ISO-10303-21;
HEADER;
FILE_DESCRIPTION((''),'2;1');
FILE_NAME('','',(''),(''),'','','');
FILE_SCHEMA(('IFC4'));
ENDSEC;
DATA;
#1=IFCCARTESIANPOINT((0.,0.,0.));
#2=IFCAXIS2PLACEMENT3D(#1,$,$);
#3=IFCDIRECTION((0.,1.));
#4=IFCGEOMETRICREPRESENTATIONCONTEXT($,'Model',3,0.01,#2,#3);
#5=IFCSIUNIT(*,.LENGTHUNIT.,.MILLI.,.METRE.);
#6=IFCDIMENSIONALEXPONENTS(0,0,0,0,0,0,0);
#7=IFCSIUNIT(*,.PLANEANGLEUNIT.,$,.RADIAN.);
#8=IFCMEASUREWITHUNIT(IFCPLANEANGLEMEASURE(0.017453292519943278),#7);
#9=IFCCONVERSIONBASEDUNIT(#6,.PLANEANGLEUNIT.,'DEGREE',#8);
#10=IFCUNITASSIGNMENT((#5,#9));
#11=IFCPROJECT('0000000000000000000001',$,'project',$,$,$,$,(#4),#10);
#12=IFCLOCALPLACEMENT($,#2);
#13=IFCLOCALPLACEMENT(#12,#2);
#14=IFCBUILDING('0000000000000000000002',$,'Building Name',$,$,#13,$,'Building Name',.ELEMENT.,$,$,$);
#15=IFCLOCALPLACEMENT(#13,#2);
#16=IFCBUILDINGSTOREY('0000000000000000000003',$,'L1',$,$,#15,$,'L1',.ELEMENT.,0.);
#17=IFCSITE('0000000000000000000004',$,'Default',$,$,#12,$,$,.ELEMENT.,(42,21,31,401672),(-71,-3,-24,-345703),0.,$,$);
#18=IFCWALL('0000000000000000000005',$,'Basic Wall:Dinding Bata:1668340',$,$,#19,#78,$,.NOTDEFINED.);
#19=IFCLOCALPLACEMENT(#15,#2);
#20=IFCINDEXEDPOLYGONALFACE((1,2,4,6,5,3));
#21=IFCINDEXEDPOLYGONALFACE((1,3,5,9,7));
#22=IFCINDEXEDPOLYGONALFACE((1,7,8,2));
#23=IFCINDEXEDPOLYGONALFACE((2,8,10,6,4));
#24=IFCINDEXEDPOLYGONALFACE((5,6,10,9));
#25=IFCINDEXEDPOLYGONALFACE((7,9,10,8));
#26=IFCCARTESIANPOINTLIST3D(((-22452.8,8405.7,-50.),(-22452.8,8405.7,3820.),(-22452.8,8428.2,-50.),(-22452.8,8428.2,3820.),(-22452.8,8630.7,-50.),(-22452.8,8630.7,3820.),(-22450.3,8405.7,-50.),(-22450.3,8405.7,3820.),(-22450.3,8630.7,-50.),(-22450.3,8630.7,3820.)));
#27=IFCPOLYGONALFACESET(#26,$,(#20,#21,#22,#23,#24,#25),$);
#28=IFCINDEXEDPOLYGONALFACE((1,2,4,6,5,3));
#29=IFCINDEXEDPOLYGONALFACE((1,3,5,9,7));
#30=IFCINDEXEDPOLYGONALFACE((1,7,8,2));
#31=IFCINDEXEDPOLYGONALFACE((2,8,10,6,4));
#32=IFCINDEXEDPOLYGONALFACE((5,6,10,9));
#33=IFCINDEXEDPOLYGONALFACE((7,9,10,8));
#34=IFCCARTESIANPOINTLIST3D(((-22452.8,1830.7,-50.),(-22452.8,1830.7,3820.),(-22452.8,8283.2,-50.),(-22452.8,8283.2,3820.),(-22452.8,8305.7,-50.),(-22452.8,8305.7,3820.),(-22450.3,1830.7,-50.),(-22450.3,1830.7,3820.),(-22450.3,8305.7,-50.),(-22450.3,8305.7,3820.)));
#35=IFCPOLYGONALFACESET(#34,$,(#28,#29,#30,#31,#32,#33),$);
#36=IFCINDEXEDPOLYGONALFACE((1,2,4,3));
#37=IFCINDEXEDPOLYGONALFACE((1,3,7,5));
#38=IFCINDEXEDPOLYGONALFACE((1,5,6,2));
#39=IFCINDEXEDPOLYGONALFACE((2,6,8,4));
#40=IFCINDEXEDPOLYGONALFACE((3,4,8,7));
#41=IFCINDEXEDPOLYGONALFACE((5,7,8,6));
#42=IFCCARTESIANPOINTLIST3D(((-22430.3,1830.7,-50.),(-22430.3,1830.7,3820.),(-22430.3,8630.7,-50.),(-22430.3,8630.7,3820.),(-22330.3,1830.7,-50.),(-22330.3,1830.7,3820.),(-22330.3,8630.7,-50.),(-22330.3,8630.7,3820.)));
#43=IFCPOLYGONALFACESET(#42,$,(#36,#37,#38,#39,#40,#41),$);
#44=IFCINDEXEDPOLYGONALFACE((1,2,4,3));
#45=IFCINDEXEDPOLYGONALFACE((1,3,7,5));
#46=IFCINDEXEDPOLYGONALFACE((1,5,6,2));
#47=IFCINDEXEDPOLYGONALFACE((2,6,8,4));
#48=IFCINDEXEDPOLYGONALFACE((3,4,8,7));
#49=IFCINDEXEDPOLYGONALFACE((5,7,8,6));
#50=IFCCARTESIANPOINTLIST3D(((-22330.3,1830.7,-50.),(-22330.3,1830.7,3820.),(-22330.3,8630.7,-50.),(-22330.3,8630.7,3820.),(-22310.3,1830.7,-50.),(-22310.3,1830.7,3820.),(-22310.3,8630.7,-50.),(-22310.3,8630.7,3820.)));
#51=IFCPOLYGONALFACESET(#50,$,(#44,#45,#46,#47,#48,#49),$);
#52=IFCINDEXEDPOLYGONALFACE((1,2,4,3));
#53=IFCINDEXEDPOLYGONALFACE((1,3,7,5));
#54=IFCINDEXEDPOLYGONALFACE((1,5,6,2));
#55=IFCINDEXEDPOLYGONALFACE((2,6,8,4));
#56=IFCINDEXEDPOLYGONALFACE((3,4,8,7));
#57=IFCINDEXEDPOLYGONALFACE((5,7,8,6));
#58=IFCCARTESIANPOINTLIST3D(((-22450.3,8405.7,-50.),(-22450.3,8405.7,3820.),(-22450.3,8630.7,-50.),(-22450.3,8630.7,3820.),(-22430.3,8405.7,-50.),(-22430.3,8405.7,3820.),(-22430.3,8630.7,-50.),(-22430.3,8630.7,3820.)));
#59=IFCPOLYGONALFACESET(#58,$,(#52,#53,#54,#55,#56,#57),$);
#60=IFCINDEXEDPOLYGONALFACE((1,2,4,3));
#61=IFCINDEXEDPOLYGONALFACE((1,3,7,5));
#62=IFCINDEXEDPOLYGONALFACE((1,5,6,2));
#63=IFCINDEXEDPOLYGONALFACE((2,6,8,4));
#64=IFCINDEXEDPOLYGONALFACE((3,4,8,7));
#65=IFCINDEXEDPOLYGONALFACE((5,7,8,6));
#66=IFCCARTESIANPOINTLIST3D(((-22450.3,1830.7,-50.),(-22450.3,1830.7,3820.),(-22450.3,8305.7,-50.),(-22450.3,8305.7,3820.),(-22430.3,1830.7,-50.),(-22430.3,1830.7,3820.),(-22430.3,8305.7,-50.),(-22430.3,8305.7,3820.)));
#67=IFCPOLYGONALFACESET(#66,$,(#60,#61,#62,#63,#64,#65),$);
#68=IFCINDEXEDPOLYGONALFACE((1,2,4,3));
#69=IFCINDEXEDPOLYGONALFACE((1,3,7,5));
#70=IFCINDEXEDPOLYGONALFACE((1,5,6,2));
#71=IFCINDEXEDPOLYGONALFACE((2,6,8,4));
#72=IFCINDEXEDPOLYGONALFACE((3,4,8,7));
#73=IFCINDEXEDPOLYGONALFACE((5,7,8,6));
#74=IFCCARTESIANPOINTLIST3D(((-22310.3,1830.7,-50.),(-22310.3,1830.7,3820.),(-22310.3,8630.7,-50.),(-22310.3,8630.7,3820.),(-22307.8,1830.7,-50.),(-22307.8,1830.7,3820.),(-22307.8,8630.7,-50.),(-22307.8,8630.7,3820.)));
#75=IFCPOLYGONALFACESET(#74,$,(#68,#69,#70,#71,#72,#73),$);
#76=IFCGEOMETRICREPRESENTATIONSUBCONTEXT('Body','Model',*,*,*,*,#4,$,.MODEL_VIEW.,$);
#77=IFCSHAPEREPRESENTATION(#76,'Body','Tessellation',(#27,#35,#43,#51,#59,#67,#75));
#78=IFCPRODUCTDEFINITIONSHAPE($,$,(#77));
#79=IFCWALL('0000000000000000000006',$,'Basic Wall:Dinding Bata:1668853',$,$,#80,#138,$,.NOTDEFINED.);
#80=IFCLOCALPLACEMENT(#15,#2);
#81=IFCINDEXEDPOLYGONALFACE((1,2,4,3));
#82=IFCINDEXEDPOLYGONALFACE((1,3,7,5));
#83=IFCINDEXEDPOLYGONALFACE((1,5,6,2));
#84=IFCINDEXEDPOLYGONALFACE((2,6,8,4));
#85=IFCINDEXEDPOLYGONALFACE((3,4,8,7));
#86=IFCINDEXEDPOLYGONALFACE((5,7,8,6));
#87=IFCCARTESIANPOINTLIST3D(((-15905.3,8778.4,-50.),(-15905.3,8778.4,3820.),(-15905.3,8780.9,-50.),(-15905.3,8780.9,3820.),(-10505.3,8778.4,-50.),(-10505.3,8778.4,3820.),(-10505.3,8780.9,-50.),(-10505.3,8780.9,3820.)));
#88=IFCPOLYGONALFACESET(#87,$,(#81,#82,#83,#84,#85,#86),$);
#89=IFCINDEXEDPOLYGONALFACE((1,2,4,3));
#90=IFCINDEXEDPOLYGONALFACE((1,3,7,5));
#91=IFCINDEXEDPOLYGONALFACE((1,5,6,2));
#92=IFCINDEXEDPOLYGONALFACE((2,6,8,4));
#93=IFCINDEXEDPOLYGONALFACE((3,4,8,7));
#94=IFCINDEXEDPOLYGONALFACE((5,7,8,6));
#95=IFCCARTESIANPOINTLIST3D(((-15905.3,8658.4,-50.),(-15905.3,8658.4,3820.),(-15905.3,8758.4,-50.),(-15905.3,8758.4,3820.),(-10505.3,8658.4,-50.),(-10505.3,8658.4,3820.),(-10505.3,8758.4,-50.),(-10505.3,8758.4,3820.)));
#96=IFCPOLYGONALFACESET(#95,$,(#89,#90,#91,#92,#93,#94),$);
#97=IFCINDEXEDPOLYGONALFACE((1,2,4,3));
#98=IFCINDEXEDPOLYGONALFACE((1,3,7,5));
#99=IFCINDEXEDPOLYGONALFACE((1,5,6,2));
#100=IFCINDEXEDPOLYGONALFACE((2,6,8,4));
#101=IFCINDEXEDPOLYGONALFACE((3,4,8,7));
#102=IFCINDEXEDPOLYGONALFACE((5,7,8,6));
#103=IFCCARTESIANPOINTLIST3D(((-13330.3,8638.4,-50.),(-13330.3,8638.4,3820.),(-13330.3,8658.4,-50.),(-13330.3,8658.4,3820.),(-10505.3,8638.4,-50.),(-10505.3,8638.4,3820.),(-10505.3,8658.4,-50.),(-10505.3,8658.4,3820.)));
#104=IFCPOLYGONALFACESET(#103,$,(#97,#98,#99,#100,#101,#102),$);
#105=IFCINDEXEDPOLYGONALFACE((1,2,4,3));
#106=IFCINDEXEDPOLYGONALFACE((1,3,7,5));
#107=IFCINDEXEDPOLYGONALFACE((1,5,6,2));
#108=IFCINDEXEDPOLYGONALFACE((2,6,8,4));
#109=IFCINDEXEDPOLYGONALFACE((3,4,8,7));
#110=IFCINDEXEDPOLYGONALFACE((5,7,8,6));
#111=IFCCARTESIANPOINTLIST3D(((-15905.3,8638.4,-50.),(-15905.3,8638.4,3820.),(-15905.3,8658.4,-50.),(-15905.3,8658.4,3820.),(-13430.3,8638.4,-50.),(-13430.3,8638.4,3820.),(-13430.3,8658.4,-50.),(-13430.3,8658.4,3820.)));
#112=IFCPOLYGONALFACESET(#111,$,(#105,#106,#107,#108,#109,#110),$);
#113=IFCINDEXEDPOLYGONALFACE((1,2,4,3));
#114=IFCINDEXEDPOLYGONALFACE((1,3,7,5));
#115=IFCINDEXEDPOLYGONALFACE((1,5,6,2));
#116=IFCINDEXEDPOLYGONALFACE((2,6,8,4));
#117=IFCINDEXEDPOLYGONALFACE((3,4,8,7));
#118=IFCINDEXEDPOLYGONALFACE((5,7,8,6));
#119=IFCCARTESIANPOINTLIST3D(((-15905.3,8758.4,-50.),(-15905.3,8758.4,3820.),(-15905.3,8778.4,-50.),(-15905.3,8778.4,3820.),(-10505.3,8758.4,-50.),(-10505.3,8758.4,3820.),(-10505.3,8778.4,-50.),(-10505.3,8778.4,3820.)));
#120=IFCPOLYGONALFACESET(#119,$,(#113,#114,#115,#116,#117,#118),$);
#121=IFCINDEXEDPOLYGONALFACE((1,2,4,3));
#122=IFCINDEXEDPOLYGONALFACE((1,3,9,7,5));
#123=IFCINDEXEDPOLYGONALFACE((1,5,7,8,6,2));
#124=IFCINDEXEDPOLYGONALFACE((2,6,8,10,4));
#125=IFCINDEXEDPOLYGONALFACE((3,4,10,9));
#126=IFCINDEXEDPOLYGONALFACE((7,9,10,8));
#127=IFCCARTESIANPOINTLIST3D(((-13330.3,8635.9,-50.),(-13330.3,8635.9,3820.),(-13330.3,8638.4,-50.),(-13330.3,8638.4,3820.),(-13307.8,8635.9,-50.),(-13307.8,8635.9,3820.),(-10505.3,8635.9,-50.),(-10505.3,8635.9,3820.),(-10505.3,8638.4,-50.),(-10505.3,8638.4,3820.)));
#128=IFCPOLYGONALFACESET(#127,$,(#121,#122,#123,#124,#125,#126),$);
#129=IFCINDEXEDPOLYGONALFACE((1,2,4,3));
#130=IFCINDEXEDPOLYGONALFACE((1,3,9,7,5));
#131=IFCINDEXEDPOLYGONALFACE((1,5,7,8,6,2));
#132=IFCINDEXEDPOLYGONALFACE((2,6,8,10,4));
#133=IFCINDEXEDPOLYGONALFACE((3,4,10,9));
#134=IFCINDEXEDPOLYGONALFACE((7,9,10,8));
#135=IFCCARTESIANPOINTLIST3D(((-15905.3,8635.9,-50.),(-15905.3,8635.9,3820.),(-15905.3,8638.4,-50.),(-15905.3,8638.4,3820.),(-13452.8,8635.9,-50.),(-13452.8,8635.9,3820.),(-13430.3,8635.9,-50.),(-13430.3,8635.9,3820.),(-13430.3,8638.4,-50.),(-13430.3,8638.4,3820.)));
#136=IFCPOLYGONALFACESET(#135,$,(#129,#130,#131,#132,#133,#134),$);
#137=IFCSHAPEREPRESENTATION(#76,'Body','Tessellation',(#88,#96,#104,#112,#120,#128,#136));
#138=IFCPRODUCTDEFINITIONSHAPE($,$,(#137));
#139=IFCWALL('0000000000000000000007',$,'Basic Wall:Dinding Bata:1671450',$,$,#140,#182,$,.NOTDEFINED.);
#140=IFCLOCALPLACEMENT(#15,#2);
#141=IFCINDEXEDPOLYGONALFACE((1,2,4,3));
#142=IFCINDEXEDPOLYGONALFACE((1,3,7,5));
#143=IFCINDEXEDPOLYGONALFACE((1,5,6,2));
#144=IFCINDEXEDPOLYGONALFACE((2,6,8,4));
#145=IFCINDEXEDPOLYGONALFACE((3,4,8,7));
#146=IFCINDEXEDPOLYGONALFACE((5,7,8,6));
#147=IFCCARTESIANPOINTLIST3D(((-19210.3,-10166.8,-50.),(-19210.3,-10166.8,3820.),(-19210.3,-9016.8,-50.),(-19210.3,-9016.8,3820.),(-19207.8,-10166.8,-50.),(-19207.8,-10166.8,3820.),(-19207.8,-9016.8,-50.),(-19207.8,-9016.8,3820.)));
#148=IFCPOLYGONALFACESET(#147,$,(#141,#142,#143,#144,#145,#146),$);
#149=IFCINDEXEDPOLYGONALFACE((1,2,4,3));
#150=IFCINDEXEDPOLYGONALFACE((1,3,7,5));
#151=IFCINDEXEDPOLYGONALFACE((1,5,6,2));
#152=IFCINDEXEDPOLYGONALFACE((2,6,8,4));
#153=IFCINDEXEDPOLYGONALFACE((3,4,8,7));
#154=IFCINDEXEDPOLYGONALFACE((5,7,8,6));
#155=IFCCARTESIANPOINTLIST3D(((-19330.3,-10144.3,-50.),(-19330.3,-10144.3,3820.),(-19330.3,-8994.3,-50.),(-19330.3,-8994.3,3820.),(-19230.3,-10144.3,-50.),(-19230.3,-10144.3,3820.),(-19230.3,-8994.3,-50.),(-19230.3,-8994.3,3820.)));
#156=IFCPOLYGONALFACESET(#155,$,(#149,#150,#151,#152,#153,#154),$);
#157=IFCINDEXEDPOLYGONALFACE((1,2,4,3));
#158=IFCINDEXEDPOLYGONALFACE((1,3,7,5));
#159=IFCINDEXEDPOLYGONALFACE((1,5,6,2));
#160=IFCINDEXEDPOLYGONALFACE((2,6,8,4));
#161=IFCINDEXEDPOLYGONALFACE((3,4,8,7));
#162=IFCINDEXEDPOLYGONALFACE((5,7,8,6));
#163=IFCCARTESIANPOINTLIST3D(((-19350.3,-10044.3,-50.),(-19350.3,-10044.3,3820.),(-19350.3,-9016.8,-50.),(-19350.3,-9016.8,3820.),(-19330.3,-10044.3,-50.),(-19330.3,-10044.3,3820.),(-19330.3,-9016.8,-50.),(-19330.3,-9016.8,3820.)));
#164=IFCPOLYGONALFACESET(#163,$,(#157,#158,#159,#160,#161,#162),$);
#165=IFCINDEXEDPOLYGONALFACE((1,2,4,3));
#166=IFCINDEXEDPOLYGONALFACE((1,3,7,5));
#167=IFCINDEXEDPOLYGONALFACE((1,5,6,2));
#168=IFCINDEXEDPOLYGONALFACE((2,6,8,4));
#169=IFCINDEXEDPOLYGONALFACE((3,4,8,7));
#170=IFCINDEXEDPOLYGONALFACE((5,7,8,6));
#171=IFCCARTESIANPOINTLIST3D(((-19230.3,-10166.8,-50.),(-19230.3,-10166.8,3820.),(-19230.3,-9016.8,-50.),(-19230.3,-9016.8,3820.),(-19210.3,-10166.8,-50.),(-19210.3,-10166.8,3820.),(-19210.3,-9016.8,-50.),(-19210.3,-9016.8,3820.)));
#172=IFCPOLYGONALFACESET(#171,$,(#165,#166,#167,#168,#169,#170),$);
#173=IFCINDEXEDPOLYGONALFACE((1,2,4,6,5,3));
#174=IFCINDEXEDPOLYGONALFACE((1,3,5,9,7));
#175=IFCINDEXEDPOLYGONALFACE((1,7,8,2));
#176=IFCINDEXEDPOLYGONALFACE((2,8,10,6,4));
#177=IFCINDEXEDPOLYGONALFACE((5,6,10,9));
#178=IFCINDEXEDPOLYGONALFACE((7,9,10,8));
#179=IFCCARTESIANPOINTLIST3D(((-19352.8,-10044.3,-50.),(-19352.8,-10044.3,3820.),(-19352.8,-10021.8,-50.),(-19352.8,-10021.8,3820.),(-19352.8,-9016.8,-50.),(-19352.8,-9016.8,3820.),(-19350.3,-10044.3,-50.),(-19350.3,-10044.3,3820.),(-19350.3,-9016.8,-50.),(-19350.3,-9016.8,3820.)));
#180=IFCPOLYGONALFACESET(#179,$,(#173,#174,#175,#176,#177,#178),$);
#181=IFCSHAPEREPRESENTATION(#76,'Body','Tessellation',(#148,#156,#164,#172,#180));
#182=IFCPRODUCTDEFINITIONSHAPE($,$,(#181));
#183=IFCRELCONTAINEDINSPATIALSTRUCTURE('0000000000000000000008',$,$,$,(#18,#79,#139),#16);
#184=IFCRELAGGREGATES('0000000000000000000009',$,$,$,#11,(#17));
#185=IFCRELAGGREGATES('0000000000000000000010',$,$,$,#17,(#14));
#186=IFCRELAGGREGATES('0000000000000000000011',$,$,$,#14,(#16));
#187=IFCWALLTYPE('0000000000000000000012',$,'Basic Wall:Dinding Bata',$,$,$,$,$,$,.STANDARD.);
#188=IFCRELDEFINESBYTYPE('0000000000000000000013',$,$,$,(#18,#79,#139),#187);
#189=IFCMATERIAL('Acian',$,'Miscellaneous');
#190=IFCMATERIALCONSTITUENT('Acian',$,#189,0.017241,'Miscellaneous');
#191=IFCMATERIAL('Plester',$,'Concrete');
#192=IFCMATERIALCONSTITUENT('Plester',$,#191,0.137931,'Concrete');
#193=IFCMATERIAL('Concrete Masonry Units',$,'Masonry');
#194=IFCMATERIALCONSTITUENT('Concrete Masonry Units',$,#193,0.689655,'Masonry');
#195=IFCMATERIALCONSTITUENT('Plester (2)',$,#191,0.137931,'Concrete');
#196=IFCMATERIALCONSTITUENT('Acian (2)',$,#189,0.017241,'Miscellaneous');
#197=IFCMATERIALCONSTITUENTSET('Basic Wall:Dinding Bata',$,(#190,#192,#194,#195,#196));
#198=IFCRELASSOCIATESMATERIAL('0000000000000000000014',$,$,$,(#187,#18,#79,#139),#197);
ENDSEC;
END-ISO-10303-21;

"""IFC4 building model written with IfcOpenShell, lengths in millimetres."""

from ifc_helpers import new_model, entity, si_unit, converted_unit, direction, frame, origin, place, context, subcontext, project, spatial, indexed_curve, outline, extrude, material, constituent, constituent_set, type_object, element, save


model = new_model("IFC4")

# Units and contexts
model_context = context("Model", 3, precision=0.01, world=origin(), true_north=direction((0.0, 1.0)))
body_context = subcontext(model_context, "Body", "Model", "MODEL_VIEW")
ifc_project = project(units=[si_unit("LENGTHUNIT", "METRE", prefix="MILLI"), converted_unit("PLANEANGLEUNIT", "DEGREE", entity("IfcPlaneAngleMeasure", 0.017453292519943278), si_unit("PLANEANGLEUNIT", "RADIAN"), dimensions=[0, 0, 0, 0, 0, 0, 0])], contexts=[model_context])

# Site, building, storey
site_placement = place(None, origin())
site = spatial("IfcSite", under=ifc_project, at=site_placement, Name="Default", CompositionType="ELEMENT", RefLatitude=(42, 21, 31, 401672), RefLongitude=(-71, -3, -24, -345703), RefElevation=0.0)
building_placement = place(site_placement, origin())
building = spatial("IfcBuilding", under=site, at=building_placement, Name="Building Name", LongName="Building Name", CompositionType="ELEMENT")
storey_placement = place(building_placement, origin())
storey = spatial("IfcBuildingStorey", under=building, at=storey_placement, Name="L1", LongName="L1", CompositionType="ELEMENT", Elevation=0.0)

# Walls
ifc_material_1 = material(Name="Acian", Category="Miscellaneous")
ifc_constituent_1 = constituent(ifc_material_1, Name="Acian", Category="Miscellaneous", fraction=0.017241)
ifc_material_2 = material(Name="Plester", Category="Concrete")
ifc_constituent_2 = constituent(ifc_material_2, Name="Plester", Category="Concrete", fraction=0.137931)
ifc_material_3 = material(Name="Concrete Masonry Units", Category="Masonry")
ifc_constituent_3 = constituent(ifc_material_3, Name="Concrete Masonry Units", Category="Masonry", fraction=0.689655)
ifc_constituent_4 = constituent(ifc_material_2, Name="Plester (2)", Category="Concrete", fraction=0.137931)
ifc_constituent_5 = constituent(ifc_material_1, Name="Acian (2)", Category="Miscellaneous", fraction=0.017241)
ifc_constituent_set = constituent_set(constituents=[ifc_constituent_1, ifc_constituent_2, ifc_constituent_3, ifc_constituent_4, ifc_constituent_5], Name="Basic Wall:Dinding Bata")
wall_type = type_object("IfcWallType", Name="Basic Wall:Dinding Bata", PredefinedType="STANDARD", material=ifc_constituent_set)
wall_1_placement = place(storey_placement, frame((-22380.3, 1830.7, -50.0), z_axis=(0.0, 0.0, 1.0), x_axis=(0.0, 1.0, 0.0)))
element("IfcWall", 1, at=wall_1_placement, inside=storey, type_object=wall_type, material=ifc_constituent_set, Name="Basic Wall:Dinding Bata:1668340", PredefinedType="NOTDEFINED", context=body_context, shape_type="SweptSolid", body=[
    extrude(outline(indexed_curve([(72.0, -1.0), (94.5, -1.0), (94.5, 1.5), (-130.5, 1.5), (-130.5, -1.0), (72.0, -1.0)], self_intersect=False)), frame((6669.5, 71.5, 0.0), z_axis=(0.0, 0.0, 1.0), x_axis=(-1.0, 0.0, 0.0)), (0.0, 0.0, 1.0), 3870.0),
    extrude(outline(indexed_curve([(-3880.5, -1.5), (2594.5, -1.5), (2594.5, 1.0), (2572.0, 1.0), (-3880.5, 1.0), (-3880.5, -1.5)], self_intersect=False)), frame((3880.5, 71.5, 0.0)), (0.0, 0.0, 1.0), 3870.0),
    extrude(outline(indexed_curve([(-3400.0, -50.0), (3400.0, -50.0), (3400.0, 50.0), (-3400.0, 50.0), (-3400.0, -50.0)], self_intersect=False)), frame((3400.0, 0.0, 0.0)), (0.0, 0.0, 1.0), 3870.0),
    extrude(outline(indexed_curve([(-3400.0, -10.0), (3400.0, -10.0), (3400.0, 10.0), (-3400.0, 10.0), (-3400.0, -10.0)], self_intersect=False)), frame((3400.0, -60.0, 0.0)), (0.0, 0.0, 1.0), 3870.0),
    extrude(outline(indexed_curve([(-112.5, -10.0), (112.5, -10.0), (112.5, 10.0), (-112.5, 10.0), (-112.5, -10.0)], self_intersect=False)), frame((6687.5, 60.0, 0.0), z_axis=(0.0, 0.0, 1.0), x_axis=(-1.0, 0.0, 0.0)), (0.0, 0.0, 1.0), 3870.0),
    extrude(outline(indexed_curve([(-3237.5, -10.0), (3237.5, -10.0), (3237.5, 10.0), (-3237.5, 10.0), (-3237.5, -10.0)], self_intersect=False)), frame((3237.5, 60.0, 0.0)), (0.0, 0.0, 1.0), 3870.0),
    extrude(outline(indexed_curve([(-1.3, -3400.0), (1.2, -3400.0), (1.3, 3400.0), (-1.2, 3400.0), (-1.3, -3400.0)], self_intersect=False)), frame((3400.0, -71.3, 0.0), z_axis=(0.0, 0.0, 1.0), x_axis=(0.0, 1.0, 0.0)), (0.0, 0.0, 1.0), 3870.0),
])
wall_2_placement = place(storey_placement, frame((-15905.3, 8708.4, -50.0)))
element("IfcWall", 2, at=wall_2_placement, inside=storey, type_object=wall_type, material=ifc_constituent_set, Name="Basic Wall:Dinding Bata:1668853", PredefinedType="NOTDEFINED", context=body_context, shape_type="SweptSolid", body=[
    extrude(outline(indexed_curve([(-1.3, -2700.0), (1.2, -2700.0), (1.3, 2700.0), (-1.2, 2700.0), (-1.3, -2700.0)], self_intersect=False)), frame((2700.0, 71.3, 0.0), z_axis=(0.0, 0.0, 1.0), x_axis=(0.0, -1.0, 0.0)), (0.0, 0.0, 1.0), 3870.0),
    extrude(outline(indexed_curve([(-2700.0, -50.0), (2700.0, -50.0), (2700.0, 50.0), (-2700.0, 50.0), (-2700.0, -50.0)], self_intersect=False)), frame((2700.0, 0.0, 0.0)), (0.0, 0.0, 1.0), 3870.0),
    extrude(outline(indexed_curve([(-1412.5, -10.0), (1412.5, -10.0), (1412.5, 10.0), (-1412.5, 10.0), (-1412.5, -10.0)], self_intersect=False)), frame((3987.5, -60.0, 0.0), z_axis=(0.0, 0.0, 1.0), x_axis=(-1.0, 0.0, 0.0)), (0.0, 0.0, 1.0), 3870.0),
    extrude(outline(indexed_curve([(-1237.5, -10.0), (1237.5, -10.0), (1237.5, 10.0), (-1237.5, 10.0), (-1237.5, -10.0)], self_intersect=False)), frame((1237.5, -60.0, 0.0)), (0.0, 0.0, 1.0), 3870.0),
    extrude(outline(indexed_curve([(-2700.0, -10.0), (2700.0, -10.0), (2700.0, 10.0), (-2700.0, 10.0), (-2700.0, -10.0)], self_intersect=False)), frame((2700.0, 60.0, 0.0)), (0.0, 0.0, 1.0), 3870.0),
    extrude(outline(indexed_curve([(-1.0, -1690.5), (1.5, -1690.5), (1.5, 1134.5), (-1.0, 1134.5), (-1.0, 1112.0), (-1.0, -1690.5)], self_intersect=False)), frame((3709.5, -71.5, 0.0), z_axis=(0.0, 0.0, 1.0), x_axis=(0.0, 1.0, 0.0)), (0.0, 0.0, 1.0), 3870.0),
    extrude(outline(indexed_curve([(972.0, -1.0), (994.5, -1.0), (994.5, 1.5), (-1480.5, 1.5), (-1480.5, -1.0), (972.0, -1.0)], self_intersect=False)), frame((1480.5, -71.5, 0.0)), (0.0, 0.0, 1.0), 3870.0),
])
wall_3_placement = place(storey_placement, frame((-19280.3, -9016.8, -50.0), z_axis=(0.0, 0.0, 1.0), x_axis=(0.0, -1.0, 0.0)))
element("IfcWall", 3, at=wall_3_placement, inside=storey, type_object=wall_type, material=ifc_constituent_set, Name="Basic Wall:Dinding Bata:1671450", PredefinedType="NOTDEFINED", context=body_context, shape_type="SweptSolid", body=[
    extrude(outline(indexed_curve([(-1.3, -575.0), (1.2, -575.0), (1.3, 575.0), (-1.2, 575.0), (-1.3, -575.0)], self_intersect=False)), frame((575.0, 71.2, 0.0), z_axis=(0.0, 0.0, 1.0), x_axis=(0.0, -1.0, 0.0)), (0.0, 0.0, 1.0), 3870.0),
    extrude(outline(indexed_curve([(-575.0, -50.0), (575.0, -50.0), (575.0, 50.0), (-575.0, 50.0), (-575.0, -50.0)], self_intersect=False)), frame((552.5, 0.0, 0.0)), (0.0, 0.0, 1.0), 3870.0),
    extrude(outline(indexed_curve([(-513.7, -10.0), (513.7, -10.0), (513.7, 10.0), (-513.7, 10.0), (-513.7, -10.0)], self_intersect=False)), frame((513.7, -60.0, 0.0)), (0.0, 0.0, 1.0), 3870.0),
    extrude(outline(indexed_curve([(-575.0, -10.0), (575.0, -10.0), (575.0, 10.0), (-575.0, 10.0), (-575.0, -10.0)], self_intersect=False)), frame((575.0, 60.0, 0.0)), (0.0, 0.0, 1.0), 3870.0),
    extrude(outline(indexed_curve([(393.0, -1.0), (415.5, -1.0), (415.5, 1.5), (-612.0, 1.5), (-612.0, -1.0), (393.0, -1.0)], self_intersect=False)), frame((612.0, -71.5, 0.0)), (0.0, 0.0, 1.0), 3870.0),
])

save(model, "model.ifc")
